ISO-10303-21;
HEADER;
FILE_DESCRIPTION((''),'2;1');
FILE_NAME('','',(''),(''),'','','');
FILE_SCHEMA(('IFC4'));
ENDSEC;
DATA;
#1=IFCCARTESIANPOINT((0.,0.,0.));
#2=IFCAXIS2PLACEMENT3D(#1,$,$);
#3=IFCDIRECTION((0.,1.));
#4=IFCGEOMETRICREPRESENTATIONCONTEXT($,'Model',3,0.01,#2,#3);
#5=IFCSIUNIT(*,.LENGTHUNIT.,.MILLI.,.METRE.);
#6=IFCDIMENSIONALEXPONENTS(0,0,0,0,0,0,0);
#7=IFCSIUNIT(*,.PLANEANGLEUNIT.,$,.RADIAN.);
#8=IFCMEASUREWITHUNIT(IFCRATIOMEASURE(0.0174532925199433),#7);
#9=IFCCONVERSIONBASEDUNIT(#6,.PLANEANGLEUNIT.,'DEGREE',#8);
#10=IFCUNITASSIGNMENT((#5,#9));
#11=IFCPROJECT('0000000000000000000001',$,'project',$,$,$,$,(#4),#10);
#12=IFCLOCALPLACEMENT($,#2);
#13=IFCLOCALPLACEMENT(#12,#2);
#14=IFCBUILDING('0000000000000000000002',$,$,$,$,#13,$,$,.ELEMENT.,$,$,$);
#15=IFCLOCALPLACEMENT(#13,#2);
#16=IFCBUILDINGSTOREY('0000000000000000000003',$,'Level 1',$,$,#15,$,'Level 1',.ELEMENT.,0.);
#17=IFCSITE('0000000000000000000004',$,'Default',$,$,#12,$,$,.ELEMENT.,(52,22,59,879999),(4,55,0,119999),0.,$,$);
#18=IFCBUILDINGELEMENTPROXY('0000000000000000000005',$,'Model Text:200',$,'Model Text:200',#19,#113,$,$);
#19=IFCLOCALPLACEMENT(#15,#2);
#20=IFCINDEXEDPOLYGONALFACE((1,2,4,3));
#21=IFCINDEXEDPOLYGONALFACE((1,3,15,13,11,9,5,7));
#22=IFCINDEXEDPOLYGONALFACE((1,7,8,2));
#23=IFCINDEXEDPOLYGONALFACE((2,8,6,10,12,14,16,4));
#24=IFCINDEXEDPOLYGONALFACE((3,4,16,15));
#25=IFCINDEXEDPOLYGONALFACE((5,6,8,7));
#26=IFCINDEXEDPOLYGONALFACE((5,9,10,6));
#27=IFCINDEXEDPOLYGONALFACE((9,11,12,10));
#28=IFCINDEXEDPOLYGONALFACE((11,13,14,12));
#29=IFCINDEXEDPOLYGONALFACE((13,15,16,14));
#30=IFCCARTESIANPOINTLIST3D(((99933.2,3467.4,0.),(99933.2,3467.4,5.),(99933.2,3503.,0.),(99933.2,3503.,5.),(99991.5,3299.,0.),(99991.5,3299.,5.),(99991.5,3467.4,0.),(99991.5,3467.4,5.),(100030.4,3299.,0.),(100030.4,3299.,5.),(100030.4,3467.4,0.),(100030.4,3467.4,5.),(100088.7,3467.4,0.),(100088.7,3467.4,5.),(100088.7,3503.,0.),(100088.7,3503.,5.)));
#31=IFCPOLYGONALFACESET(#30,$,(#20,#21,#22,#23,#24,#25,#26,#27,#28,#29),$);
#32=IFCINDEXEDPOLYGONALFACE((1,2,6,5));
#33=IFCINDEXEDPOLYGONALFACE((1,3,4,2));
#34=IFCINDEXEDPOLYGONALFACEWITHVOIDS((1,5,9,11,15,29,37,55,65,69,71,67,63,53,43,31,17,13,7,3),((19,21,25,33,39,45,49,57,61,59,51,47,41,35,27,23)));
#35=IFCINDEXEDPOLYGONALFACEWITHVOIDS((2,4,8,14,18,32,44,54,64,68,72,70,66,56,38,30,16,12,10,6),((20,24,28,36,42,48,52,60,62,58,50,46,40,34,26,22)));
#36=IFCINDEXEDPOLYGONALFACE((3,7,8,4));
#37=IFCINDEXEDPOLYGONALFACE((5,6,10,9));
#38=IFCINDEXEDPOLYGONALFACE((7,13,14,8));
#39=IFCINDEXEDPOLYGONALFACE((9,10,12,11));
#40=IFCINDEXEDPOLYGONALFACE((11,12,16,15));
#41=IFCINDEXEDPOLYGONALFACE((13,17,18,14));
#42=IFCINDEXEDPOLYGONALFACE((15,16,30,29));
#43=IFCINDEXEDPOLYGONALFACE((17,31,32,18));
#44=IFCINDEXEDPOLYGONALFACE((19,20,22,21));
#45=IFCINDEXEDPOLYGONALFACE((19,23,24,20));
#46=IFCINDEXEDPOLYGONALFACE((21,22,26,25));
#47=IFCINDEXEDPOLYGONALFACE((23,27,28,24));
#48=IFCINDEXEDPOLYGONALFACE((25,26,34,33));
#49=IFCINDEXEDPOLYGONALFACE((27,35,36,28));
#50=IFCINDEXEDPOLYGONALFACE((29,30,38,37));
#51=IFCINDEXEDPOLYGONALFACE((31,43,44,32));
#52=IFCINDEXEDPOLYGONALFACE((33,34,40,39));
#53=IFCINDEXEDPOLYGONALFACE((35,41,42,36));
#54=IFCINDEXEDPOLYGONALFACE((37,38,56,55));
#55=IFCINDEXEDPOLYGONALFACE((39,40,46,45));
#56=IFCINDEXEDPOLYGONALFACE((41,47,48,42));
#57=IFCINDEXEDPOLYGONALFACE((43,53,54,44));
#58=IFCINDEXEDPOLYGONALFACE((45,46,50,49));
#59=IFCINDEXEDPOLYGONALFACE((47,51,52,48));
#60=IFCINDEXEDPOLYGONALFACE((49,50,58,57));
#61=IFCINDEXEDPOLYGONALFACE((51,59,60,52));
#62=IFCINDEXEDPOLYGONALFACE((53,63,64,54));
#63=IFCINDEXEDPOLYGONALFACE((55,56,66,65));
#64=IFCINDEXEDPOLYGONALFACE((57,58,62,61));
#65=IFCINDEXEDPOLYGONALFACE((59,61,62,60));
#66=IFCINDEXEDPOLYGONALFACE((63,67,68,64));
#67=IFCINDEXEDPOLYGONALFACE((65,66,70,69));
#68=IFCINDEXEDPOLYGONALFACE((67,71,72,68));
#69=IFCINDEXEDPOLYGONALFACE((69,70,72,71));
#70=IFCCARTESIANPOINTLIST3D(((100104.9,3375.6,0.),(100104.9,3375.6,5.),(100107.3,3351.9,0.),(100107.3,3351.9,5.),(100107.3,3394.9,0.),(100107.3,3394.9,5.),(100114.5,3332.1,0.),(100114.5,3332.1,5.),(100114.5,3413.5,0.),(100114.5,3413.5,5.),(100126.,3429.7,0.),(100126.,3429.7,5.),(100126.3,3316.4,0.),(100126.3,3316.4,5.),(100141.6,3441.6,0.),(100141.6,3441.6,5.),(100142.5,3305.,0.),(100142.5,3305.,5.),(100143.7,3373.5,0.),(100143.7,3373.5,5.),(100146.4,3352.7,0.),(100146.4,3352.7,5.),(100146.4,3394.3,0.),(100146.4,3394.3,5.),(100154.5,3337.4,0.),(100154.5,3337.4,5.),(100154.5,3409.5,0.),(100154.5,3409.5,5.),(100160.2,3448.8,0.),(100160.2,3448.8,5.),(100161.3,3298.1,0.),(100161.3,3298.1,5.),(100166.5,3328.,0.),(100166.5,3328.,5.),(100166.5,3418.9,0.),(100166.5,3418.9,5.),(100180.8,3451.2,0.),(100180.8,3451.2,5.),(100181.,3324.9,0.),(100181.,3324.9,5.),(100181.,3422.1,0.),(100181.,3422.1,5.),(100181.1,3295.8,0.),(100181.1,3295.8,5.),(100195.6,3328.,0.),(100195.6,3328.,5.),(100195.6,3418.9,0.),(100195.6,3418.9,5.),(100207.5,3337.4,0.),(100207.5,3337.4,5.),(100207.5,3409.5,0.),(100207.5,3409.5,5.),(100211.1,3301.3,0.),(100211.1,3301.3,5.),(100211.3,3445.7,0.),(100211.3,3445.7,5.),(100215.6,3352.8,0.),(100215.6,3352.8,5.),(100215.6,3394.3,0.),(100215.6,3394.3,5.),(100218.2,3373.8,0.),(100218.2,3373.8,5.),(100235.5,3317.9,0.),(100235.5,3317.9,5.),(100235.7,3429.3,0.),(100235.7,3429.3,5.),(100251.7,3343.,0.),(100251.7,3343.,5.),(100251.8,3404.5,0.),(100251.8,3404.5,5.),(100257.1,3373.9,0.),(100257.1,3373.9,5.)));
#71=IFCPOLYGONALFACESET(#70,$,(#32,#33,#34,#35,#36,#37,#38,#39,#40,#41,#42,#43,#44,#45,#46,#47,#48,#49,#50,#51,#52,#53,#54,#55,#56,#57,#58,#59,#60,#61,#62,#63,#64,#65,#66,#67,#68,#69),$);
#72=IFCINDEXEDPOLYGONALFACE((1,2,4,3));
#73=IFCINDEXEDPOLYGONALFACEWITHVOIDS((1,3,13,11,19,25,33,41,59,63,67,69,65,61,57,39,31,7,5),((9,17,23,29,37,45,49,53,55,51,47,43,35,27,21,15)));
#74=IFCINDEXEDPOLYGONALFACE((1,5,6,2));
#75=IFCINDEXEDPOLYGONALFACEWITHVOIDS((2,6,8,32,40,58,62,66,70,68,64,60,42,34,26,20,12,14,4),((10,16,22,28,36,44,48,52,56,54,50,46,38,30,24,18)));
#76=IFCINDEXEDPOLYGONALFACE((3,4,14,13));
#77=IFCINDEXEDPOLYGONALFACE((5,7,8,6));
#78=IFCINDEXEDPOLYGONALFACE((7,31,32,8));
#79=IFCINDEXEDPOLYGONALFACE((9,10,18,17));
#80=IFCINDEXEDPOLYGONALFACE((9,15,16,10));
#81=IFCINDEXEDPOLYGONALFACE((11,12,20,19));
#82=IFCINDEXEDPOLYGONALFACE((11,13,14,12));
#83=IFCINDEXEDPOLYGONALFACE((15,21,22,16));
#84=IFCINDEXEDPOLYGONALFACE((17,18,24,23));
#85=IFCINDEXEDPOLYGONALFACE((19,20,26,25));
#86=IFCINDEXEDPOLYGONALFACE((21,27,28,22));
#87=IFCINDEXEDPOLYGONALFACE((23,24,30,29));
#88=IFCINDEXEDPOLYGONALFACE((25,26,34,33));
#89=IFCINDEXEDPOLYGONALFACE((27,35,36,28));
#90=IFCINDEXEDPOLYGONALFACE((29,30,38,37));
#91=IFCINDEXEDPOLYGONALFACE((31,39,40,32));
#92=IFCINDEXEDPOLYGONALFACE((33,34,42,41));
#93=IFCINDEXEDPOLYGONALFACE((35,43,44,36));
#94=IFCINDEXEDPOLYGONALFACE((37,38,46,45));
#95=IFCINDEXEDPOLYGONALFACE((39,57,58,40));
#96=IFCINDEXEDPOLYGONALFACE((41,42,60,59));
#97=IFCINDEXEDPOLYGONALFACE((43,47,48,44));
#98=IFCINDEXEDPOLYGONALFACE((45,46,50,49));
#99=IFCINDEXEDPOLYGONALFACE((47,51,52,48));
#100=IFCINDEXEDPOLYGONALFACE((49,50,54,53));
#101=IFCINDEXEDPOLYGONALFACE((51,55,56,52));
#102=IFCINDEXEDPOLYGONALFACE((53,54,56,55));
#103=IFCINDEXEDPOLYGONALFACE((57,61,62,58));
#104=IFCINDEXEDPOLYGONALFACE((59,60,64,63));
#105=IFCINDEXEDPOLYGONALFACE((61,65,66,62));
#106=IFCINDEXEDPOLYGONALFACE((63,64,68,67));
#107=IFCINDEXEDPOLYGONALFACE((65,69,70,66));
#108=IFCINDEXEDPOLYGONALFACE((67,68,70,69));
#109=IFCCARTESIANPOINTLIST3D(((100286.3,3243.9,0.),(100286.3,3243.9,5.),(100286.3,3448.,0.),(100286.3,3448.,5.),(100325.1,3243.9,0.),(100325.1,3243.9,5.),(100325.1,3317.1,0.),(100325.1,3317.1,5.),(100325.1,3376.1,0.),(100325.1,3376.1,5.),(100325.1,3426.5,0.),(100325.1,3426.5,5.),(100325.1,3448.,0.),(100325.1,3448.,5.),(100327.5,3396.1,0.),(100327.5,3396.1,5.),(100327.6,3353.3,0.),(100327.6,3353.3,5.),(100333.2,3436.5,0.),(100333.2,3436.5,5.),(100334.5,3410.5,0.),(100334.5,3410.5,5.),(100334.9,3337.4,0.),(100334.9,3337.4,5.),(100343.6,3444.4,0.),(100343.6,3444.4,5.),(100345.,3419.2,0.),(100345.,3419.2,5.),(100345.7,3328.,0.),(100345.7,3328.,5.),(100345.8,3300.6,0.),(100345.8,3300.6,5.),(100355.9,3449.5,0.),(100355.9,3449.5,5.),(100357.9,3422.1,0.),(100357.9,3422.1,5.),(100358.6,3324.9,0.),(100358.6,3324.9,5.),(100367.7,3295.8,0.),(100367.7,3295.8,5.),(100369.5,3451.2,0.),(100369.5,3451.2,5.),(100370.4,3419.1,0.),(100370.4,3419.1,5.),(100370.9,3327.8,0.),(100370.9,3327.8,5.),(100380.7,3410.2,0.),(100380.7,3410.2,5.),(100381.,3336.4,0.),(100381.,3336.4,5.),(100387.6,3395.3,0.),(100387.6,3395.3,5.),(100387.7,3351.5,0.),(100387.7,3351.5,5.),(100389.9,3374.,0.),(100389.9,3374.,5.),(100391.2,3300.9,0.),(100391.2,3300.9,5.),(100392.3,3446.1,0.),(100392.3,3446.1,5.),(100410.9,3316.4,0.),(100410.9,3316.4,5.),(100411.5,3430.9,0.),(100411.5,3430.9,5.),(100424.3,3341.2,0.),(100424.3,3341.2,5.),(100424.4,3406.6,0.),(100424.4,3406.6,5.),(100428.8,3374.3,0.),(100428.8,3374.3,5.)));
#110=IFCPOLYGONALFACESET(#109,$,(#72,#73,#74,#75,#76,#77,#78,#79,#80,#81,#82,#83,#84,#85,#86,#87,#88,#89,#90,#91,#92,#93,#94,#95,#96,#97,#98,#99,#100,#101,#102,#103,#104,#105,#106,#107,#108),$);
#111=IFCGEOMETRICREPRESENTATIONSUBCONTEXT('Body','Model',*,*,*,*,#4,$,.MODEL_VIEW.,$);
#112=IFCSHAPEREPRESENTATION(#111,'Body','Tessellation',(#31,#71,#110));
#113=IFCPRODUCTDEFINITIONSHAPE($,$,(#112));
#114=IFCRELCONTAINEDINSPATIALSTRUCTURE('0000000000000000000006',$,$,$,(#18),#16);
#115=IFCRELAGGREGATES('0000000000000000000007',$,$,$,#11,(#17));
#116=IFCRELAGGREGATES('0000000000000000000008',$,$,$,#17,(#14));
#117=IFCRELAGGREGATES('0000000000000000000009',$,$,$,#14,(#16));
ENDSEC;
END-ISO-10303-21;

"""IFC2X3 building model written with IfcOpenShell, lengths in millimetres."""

from ifc_helpers import new_model, entity, si_unit, converted_unit, direction, frame, origin, place, context, subcontext, project, spatial, polyline, outline, extrude, element, save


model = new_model("IFC2X3")

# Units and contexts
model_context = context("Model", 3, precision=0.01, world=origin(), true_north=direction((0.0, 1.0)))
body_context = subcontext(model_context, "Body", "Model", "MODEL_VIEW")
ifc_project = project(units=[si_unit("LENGTHUNIT", "METRE", prefix="MILLI"), converted_unit("PLANEANGLEUNIT", "DEGREE", entity("IfcRatioMeasure", 0.0174532925199433), si_unit("PLANEANGLEUNIT", "RADIAN"), dimensions=[0, 0, 0, 0, 0, 0, 0])], contexts=[model_context])

# Site, building, storey
site_placement = place(None, origin())
site = spatial("IfcSite", under=ifc_project, at=site_placement, Name="Default", CompositionType="ELEMENT", RefLatitude=(52, 22, 59, 879999), RefLongitude=(4, 55, 0, 119999), RefElevation=0.0)
building_placement = place(site_placement, origin())
building = spatial("IfcBuilding", under=site, at=building_placement, CompositionType="ELEMENT")
storey_placement = place(building_placement, origin())
storey = spatial("IfcBuildingStorey", under=building, at=storey_placement, Name="Level 1", LongName="Level 1", CompositionType="ELEMENT", Elevation=0.0)

# Building element proxy
proxy_1_placement = place(building_placement, origin())
element("IfcBuildingElementProxy", 1, at=proxy_1_placement, inside=storey, Name="Model Text:200", ObjectType="Model Text:200", context=body_context, shape_type="SweptSolid", body=[
    extrude(outline(polyline([(-19.4, -135.2), (19.4, -135.2), (19.4, 33.2), (77.7, 33.2), (77.7, 68.8), (-77.7, 68.8), (-77.7, 33.2), (-19.4, 33.2), (-19.4, -135.2)])), frame((100010.9, 3434.2, 0.0)), (0.0, 0.0, 1.0), 5.0),
    extrude(outline(polyline([(-8.8, -65.7), (15.1, -65.7), (35.5, -60.5), (52.3, -50.4), (65.3, -35.4), (74.1, -17.3), (78.4, 2.1), (75.9, 32.5), (61.8, 58.5), (38.4, 77.1), (8.3, 85.6), (-22.7, 83.3), (-49.0, 69.9), (-67.8, 47.3), (-76.3, 17.5), (-76.0, -3.3), (-70.7, -22.5), (-60.5, -39.2), (-45.5, -52.3), (-27.7, -61.4), (-8.8, -65.7)]), holes=[polyline([(-2.7, -27.2), (-23.1, -22.5), (-37.5, -12.9), (-45.7, 0.0), (-47.3, 14.8), (-42.7, 28.9), (-32.2, 39.9), (-16.3, 46.3), (4.5, 46.9), (25.1, 42.1), (39.6, 32.6), (47.7, 19.7), (49.4, 5.0), (44.8, -9.2), (34.2, -20.2), (18.2, -26.7), (-2.7, -27.2)])]), frame((100171.1, 3373.5, 0.0), z_axis=(0.0, 0.0, 1.0), x_axis=(0.100608, -0.994926, 0.0)), (0.0, 0.0, 1.0), 5.0),
    extrude(outline(polyline([(-73.1, -75.4), (130.9, -75.4), (130.9, -36.6), (57.8, -36.6), (74.3, -15.9), (79.1, 6.0), (73.9, 29.5), (58.4, 49.2), (33.6, 62.6), (0.5, 67.1), (-31.8, 62.8), (-56.1, 49.8), (-71.3, 30.7), (-76.4, 7.8), (-74.7, -5.8), (-69.6, -18.1), (-61.7, -28.5), (-51.7, -36.6), (-73.1, -36.6), (-73.1, -75.4)]), holes=[polyline([(-1.2, -36.6), (-21.2, -34.2), (-35.6, -27.2), (-44.3, -16.7), (-47.2, -3.8), (-44.3, 8.7), (-35.4, 19.0), (-20.4, 25.9), (0.8, 28.2), (23.3, 26.0), (38.5, 19.3), (47.1, 9.2), (49.9, -3.1), (46.8, -16.0), (37.4, -26.8), (21.5, -34.1), (-1.2, -36.6)])]), frame((100361.7, 3374.8, 0.0), z_axis=(0.0, 0.0, 1.0), x_axis=(0.0, -1.0, 0.0)), (0.0, 0.0, 1.0), 5.0),
])

save(model, "model.ifc")
